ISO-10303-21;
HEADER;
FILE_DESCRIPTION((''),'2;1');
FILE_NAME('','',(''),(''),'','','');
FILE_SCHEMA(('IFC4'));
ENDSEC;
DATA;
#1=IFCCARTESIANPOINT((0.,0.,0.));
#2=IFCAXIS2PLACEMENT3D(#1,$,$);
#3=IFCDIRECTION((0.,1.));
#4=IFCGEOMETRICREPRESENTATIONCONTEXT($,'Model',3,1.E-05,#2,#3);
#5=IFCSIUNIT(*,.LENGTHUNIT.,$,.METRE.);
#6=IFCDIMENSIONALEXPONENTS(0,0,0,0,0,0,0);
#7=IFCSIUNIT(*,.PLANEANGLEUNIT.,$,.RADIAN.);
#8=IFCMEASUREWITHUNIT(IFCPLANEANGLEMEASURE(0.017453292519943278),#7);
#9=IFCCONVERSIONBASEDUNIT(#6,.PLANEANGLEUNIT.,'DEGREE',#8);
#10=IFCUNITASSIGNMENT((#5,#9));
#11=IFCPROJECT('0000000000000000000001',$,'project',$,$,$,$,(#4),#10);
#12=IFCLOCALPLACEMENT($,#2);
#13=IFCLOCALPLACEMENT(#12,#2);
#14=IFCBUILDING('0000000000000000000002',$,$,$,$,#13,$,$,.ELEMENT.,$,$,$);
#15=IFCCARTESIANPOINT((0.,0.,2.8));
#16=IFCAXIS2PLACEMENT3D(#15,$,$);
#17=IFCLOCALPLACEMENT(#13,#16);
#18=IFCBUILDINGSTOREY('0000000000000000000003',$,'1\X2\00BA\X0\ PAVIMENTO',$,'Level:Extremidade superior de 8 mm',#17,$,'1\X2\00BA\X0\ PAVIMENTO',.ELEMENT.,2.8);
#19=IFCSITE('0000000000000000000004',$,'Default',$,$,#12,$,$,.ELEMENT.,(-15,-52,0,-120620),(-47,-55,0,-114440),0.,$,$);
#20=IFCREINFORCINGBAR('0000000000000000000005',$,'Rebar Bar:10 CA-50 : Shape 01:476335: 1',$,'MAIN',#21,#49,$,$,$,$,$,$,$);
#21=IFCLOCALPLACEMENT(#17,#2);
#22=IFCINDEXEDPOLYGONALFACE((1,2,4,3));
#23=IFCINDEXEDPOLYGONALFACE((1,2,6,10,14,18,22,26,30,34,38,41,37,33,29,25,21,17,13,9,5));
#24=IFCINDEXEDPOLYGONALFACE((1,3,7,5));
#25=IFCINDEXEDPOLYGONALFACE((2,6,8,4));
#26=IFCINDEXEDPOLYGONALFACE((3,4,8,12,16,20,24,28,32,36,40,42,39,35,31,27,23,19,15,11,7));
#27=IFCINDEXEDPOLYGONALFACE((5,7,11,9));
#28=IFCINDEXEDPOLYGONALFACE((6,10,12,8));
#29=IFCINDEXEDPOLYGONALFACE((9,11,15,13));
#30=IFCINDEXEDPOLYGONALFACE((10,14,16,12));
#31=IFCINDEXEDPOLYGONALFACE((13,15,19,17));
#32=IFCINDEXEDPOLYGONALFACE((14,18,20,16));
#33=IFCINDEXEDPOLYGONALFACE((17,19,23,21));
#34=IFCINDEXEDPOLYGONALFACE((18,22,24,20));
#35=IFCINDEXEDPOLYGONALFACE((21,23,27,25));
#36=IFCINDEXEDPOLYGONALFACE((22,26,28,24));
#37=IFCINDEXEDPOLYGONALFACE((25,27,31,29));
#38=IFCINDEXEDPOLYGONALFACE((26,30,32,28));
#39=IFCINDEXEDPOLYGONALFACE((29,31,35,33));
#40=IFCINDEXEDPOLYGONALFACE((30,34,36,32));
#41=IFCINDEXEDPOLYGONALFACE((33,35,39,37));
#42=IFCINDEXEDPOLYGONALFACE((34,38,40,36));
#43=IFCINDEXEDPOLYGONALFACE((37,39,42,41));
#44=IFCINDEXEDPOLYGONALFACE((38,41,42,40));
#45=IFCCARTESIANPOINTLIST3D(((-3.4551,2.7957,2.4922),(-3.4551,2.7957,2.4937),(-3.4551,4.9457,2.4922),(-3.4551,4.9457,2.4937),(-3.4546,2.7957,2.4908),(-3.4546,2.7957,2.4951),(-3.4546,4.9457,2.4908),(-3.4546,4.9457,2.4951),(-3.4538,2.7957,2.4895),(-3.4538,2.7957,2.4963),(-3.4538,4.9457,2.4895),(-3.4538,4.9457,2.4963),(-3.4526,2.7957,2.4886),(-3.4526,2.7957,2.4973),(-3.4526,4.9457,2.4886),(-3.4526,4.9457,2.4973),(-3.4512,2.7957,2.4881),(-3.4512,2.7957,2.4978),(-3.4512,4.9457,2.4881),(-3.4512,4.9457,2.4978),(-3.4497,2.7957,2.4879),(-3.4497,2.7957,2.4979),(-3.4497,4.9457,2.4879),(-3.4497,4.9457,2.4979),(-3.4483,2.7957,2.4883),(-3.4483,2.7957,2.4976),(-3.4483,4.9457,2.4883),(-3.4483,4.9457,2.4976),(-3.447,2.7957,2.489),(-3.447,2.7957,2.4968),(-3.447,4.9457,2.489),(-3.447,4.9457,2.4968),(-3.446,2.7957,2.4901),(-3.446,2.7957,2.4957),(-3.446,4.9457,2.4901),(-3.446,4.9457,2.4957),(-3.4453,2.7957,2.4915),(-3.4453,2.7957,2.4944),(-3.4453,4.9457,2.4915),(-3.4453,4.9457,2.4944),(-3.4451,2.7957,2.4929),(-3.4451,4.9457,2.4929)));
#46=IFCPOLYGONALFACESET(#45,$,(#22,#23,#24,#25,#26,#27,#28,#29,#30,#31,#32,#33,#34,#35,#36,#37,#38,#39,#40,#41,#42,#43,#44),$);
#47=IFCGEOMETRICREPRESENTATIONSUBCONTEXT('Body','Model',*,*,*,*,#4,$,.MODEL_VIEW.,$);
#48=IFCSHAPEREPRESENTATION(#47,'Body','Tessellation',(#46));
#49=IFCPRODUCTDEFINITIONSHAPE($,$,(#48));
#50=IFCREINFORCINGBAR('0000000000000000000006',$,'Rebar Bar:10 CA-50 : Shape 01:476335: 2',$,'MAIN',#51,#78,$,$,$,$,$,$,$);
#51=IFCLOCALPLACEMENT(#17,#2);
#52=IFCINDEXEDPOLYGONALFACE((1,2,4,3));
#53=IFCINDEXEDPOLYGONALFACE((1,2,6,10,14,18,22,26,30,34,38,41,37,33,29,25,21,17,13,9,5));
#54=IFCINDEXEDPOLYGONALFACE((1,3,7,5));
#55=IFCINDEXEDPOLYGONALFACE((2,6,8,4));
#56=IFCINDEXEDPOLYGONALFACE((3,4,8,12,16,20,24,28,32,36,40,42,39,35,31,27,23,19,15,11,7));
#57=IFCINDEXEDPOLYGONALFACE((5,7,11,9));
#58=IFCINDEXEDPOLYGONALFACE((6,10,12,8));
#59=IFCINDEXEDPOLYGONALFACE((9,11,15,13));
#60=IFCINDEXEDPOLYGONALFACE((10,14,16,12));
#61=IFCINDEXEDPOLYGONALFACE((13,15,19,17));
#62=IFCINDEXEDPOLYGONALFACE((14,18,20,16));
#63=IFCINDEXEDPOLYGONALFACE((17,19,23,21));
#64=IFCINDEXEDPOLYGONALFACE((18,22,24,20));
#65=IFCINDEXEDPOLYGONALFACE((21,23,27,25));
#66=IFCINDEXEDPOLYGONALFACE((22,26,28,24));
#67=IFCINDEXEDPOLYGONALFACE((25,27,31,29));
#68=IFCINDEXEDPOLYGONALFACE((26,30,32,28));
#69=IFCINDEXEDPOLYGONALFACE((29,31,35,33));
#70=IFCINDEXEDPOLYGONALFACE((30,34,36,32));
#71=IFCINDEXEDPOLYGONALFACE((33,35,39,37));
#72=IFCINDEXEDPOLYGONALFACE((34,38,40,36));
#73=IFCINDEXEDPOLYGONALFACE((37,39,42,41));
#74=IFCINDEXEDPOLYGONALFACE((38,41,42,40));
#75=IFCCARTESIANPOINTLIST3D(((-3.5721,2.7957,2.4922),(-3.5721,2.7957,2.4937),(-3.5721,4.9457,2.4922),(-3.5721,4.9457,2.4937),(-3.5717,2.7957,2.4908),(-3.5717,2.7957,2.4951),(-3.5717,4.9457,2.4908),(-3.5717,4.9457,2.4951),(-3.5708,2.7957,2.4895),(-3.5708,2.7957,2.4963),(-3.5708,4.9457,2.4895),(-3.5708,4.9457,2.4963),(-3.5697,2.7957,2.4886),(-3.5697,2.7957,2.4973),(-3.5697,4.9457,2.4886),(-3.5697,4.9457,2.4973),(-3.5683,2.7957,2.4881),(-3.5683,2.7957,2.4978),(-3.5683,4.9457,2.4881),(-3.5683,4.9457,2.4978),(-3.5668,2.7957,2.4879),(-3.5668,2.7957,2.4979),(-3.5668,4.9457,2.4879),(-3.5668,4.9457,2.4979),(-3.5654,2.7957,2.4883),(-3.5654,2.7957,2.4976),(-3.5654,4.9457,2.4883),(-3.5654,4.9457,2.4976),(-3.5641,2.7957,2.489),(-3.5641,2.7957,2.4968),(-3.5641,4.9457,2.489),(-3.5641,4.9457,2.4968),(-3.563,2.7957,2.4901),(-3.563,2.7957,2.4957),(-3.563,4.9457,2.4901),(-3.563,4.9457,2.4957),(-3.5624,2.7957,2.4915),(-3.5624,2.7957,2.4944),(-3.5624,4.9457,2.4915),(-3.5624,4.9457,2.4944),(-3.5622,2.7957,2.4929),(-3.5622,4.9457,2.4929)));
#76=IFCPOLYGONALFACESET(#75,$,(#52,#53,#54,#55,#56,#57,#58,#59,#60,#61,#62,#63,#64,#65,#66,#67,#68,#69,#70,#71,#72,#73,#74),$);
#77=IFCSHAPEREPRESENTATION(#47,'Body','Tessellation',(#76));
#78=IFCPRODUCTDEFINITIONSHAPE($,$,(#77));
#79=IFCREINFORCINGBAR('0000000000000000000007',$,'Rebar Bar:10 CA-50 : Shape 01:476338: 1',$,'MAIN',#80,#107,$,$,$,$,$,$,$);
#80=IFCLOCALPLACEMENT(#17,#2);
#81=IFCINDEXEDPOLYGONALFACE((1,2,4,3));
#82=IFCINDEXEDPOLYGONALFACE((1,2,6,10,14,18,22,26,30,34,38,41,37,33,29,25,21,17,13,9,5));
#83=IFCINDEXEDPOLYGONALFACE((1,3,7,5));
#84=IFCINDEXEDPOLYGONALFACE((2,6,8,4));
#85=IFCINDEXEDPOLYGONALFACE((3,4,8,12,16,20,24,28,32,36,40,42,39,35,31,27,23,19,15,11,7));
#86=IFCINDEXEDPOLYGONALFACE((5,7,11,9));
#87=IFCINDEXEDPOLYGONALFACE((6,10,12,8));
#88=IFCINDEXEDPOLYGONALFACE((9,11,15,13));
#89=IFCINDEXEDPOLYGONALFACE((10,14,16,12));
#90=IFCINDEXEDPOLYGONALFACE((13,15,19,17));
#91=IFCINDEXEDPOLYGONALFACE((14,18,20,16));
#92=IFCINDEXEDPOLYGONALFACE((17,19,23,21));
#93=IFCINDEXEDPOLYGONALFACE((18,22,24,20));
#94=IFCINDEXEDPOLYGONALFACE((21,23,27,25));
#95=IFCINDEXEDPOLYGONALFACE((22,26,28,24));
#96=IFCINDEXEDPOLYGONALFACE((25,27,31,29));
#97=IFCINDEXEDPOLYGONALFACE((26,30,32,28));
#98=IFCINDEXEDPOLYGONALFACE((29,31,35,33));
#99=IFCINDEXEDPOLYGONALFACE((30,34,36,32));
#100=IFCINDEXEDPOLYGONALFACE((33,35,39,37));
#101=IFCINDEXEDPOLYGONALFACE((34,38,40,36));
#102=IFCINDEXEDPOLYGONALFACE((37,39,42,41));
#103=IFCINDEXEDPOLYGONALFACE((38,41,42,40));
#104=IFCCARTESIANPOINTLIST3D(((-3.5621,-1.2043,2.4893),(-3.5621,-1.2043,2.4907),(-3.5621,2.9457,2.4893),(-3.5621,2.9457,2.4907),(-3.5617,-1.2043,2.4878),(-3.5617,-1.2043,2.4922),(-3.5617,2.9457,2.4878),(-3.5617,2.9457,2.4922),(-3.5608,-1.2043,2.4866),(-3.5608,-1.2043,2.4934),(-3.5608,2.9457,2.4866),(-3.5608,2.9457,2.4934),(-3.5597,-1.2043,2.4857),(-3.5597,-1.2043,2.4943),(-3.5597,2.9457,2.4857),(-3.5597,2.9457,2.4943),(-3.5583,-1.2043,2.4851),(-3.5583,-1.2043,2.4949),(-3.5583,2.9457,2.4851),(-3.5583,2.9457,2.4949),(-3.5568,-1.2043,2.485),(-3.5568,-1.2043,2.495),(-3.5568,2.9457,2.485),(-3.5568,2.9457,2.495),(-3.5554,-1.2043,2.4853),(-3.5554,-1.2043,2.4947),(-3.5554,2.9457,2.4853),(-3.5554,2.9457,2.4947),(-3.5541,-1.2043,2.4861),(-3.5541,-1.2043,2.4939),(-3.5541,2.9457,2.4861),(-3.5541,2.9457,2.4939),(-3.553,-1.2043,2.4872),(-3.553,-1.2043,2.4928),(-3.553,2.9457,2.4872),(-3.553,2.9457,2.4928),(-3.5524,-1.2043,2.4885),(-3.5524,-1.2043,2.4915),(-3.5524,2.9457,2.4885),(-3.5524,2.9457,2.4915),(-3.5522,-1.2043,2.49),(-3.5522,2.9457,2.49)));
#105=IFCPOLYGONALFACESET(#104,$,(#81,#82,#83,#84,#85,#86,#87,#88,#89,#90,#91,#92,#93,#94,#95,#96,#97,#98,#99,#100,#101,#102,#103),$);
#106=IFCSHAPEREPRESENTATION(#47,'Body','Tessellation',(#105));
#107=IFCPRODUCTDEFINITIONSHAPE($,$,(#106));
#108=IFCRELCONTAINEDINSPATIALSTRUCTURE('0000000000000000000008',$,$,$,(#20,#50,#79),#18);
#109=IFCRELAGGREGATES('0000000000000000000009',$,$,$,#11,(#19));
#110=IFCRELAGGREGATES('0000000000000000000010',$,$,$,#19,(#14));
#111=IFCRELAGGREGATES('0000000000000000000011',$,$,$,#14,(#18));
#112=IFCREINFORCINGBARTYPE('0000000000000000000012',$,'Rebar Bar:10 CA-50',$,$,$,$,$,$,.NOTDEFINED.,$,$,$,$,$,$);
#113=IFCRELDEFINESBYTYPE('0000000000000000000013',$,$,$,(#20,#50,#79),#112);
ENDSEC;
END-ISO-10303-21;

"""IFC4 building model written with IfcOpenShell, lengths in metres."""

from ifc_helpers import new_model, entity, si_unit, converted_unit, direction, frame, origin, place, context, subcontext, project, spatial, type_object, element, save


model = new_model("IFC4")

# Units and contexts
model_context = context("Model", 3, precision=1e-05, world=origin(), true_north=direction((0.0, 1.0)))
body_context = subcontext(model_context, "Body", "Model", "MODEL_VIEW")
ifc_project = project(units=[si_unit("LENGTHUNIT", "METRE"), converted_unit("PLANEANGLEUNIT", "DEGREE", entity("IfcPlaneAngleMeasure", 0.017453292519943278), si_unit("PLANEANGLEUNIT", "RADIAN"), dimensions=[0, 0, 0, 0, 0, 0, 0])], contexts=[model_context])

# Site, building, storey
site_placement = place(None, origin())
site = spatial("IfcSite", under=ifc_project, at=site_placement, Name="Default", CompositionType="ELEMENT", RefLatitude=(-15, -52, 0, -120620), RefLongitude=(-47, -55, 0, -114440), RefElevation=0.0)
building_placement = place(site_placement, origin())
building = spatial("IfcBuilding", under=site, at=building_placement, CompositionType="ELEMENT")
storey_placement = place(building_placement, frame((0.0, 0.0, 2.8)))
storey = spatial("IfcBuildingStorey", under=building, at=storey_placement, Name="1º PAVIMENTO", ObjectType="Level:Extremidade superior de 8 mm", LongName="1º PAVIMENTO", CompositionType="ELEMENT", Elevation=2.8)

# Reinforcing bars
reinforcing_bar_type = type_object("IfcReinforcingBarType", Name="Rebar Bar:10 CA-50", PredefinedType="NOTDEFINED")
reinforcing_bar_1_placement = place(storey_placement, origin())
element("IfcReinforcingBar", 1, at=reinforcing_bar_1_placement, inside=storey, type_object=reinforcing_bar_type, Name="Rebar Bar:10 CA-50 : Shape 01:476335: 1", ObjectType="MAIN", context=body_context, shape_type="AdvancedSweptSolid", body=[
    entity("IfcSweptDiskSolid", entity("IfcIndexedPolyCurve", entity("IfcCartesianPointList3D", [[-3.4501, 2.7957, 2.4929], [-3.4501, 4.9457, 2.4929]]), None, False), 0.005, None, 0.0, 1.0),
])
reinforcing_bar_2_placement = place(storey_placement, origin())
element("IfcReinforcingBar", 2, at=reinforcing_bar_2_placement, inside=storey, type_object=reinforcing_bar_type, Name="Rebar Bar:10 CA-50 : Shape 01:476335: 2", ObjectType="MAIN", context=body_context, shape_type="AdvancedSweptSolid", body=[
    entity("IfcSweptDiskSolid", entity("IfcIndexedPolyCurve", entity("IfcCartesianPointList3D", [[-3.5672, 2.7957, 2.4929], [-3.5672, 4.9457, 2.4929]]), None, False), 0.005, None, 0.0, 1.0),
])
reinforcing_bar_3_placement = place(storey_placement, origin())
element("IfcReinforcingBar", 3, at=reinforcing_bar_3_placement, inside=storey, type_object=reinforcing_bar_type, Name="Rebar Bar:10 CA-50 : Shape 01:476338: 1", ObjectType="MAIN", context=body_context, shape_type="AdvancedSweptSolid", body=[
    entity("IfcSweptDiskSolid", entity("IfcIndexedPolyCurve", entity("IfcCartesianPointList3D", [[-3.5572, -1.2043, 2.49], [-3.5572, 2.9457, 2.49]]), None, False), 0.005, None, 0.0, 1.0),
])

save(model, "model.ifc")
